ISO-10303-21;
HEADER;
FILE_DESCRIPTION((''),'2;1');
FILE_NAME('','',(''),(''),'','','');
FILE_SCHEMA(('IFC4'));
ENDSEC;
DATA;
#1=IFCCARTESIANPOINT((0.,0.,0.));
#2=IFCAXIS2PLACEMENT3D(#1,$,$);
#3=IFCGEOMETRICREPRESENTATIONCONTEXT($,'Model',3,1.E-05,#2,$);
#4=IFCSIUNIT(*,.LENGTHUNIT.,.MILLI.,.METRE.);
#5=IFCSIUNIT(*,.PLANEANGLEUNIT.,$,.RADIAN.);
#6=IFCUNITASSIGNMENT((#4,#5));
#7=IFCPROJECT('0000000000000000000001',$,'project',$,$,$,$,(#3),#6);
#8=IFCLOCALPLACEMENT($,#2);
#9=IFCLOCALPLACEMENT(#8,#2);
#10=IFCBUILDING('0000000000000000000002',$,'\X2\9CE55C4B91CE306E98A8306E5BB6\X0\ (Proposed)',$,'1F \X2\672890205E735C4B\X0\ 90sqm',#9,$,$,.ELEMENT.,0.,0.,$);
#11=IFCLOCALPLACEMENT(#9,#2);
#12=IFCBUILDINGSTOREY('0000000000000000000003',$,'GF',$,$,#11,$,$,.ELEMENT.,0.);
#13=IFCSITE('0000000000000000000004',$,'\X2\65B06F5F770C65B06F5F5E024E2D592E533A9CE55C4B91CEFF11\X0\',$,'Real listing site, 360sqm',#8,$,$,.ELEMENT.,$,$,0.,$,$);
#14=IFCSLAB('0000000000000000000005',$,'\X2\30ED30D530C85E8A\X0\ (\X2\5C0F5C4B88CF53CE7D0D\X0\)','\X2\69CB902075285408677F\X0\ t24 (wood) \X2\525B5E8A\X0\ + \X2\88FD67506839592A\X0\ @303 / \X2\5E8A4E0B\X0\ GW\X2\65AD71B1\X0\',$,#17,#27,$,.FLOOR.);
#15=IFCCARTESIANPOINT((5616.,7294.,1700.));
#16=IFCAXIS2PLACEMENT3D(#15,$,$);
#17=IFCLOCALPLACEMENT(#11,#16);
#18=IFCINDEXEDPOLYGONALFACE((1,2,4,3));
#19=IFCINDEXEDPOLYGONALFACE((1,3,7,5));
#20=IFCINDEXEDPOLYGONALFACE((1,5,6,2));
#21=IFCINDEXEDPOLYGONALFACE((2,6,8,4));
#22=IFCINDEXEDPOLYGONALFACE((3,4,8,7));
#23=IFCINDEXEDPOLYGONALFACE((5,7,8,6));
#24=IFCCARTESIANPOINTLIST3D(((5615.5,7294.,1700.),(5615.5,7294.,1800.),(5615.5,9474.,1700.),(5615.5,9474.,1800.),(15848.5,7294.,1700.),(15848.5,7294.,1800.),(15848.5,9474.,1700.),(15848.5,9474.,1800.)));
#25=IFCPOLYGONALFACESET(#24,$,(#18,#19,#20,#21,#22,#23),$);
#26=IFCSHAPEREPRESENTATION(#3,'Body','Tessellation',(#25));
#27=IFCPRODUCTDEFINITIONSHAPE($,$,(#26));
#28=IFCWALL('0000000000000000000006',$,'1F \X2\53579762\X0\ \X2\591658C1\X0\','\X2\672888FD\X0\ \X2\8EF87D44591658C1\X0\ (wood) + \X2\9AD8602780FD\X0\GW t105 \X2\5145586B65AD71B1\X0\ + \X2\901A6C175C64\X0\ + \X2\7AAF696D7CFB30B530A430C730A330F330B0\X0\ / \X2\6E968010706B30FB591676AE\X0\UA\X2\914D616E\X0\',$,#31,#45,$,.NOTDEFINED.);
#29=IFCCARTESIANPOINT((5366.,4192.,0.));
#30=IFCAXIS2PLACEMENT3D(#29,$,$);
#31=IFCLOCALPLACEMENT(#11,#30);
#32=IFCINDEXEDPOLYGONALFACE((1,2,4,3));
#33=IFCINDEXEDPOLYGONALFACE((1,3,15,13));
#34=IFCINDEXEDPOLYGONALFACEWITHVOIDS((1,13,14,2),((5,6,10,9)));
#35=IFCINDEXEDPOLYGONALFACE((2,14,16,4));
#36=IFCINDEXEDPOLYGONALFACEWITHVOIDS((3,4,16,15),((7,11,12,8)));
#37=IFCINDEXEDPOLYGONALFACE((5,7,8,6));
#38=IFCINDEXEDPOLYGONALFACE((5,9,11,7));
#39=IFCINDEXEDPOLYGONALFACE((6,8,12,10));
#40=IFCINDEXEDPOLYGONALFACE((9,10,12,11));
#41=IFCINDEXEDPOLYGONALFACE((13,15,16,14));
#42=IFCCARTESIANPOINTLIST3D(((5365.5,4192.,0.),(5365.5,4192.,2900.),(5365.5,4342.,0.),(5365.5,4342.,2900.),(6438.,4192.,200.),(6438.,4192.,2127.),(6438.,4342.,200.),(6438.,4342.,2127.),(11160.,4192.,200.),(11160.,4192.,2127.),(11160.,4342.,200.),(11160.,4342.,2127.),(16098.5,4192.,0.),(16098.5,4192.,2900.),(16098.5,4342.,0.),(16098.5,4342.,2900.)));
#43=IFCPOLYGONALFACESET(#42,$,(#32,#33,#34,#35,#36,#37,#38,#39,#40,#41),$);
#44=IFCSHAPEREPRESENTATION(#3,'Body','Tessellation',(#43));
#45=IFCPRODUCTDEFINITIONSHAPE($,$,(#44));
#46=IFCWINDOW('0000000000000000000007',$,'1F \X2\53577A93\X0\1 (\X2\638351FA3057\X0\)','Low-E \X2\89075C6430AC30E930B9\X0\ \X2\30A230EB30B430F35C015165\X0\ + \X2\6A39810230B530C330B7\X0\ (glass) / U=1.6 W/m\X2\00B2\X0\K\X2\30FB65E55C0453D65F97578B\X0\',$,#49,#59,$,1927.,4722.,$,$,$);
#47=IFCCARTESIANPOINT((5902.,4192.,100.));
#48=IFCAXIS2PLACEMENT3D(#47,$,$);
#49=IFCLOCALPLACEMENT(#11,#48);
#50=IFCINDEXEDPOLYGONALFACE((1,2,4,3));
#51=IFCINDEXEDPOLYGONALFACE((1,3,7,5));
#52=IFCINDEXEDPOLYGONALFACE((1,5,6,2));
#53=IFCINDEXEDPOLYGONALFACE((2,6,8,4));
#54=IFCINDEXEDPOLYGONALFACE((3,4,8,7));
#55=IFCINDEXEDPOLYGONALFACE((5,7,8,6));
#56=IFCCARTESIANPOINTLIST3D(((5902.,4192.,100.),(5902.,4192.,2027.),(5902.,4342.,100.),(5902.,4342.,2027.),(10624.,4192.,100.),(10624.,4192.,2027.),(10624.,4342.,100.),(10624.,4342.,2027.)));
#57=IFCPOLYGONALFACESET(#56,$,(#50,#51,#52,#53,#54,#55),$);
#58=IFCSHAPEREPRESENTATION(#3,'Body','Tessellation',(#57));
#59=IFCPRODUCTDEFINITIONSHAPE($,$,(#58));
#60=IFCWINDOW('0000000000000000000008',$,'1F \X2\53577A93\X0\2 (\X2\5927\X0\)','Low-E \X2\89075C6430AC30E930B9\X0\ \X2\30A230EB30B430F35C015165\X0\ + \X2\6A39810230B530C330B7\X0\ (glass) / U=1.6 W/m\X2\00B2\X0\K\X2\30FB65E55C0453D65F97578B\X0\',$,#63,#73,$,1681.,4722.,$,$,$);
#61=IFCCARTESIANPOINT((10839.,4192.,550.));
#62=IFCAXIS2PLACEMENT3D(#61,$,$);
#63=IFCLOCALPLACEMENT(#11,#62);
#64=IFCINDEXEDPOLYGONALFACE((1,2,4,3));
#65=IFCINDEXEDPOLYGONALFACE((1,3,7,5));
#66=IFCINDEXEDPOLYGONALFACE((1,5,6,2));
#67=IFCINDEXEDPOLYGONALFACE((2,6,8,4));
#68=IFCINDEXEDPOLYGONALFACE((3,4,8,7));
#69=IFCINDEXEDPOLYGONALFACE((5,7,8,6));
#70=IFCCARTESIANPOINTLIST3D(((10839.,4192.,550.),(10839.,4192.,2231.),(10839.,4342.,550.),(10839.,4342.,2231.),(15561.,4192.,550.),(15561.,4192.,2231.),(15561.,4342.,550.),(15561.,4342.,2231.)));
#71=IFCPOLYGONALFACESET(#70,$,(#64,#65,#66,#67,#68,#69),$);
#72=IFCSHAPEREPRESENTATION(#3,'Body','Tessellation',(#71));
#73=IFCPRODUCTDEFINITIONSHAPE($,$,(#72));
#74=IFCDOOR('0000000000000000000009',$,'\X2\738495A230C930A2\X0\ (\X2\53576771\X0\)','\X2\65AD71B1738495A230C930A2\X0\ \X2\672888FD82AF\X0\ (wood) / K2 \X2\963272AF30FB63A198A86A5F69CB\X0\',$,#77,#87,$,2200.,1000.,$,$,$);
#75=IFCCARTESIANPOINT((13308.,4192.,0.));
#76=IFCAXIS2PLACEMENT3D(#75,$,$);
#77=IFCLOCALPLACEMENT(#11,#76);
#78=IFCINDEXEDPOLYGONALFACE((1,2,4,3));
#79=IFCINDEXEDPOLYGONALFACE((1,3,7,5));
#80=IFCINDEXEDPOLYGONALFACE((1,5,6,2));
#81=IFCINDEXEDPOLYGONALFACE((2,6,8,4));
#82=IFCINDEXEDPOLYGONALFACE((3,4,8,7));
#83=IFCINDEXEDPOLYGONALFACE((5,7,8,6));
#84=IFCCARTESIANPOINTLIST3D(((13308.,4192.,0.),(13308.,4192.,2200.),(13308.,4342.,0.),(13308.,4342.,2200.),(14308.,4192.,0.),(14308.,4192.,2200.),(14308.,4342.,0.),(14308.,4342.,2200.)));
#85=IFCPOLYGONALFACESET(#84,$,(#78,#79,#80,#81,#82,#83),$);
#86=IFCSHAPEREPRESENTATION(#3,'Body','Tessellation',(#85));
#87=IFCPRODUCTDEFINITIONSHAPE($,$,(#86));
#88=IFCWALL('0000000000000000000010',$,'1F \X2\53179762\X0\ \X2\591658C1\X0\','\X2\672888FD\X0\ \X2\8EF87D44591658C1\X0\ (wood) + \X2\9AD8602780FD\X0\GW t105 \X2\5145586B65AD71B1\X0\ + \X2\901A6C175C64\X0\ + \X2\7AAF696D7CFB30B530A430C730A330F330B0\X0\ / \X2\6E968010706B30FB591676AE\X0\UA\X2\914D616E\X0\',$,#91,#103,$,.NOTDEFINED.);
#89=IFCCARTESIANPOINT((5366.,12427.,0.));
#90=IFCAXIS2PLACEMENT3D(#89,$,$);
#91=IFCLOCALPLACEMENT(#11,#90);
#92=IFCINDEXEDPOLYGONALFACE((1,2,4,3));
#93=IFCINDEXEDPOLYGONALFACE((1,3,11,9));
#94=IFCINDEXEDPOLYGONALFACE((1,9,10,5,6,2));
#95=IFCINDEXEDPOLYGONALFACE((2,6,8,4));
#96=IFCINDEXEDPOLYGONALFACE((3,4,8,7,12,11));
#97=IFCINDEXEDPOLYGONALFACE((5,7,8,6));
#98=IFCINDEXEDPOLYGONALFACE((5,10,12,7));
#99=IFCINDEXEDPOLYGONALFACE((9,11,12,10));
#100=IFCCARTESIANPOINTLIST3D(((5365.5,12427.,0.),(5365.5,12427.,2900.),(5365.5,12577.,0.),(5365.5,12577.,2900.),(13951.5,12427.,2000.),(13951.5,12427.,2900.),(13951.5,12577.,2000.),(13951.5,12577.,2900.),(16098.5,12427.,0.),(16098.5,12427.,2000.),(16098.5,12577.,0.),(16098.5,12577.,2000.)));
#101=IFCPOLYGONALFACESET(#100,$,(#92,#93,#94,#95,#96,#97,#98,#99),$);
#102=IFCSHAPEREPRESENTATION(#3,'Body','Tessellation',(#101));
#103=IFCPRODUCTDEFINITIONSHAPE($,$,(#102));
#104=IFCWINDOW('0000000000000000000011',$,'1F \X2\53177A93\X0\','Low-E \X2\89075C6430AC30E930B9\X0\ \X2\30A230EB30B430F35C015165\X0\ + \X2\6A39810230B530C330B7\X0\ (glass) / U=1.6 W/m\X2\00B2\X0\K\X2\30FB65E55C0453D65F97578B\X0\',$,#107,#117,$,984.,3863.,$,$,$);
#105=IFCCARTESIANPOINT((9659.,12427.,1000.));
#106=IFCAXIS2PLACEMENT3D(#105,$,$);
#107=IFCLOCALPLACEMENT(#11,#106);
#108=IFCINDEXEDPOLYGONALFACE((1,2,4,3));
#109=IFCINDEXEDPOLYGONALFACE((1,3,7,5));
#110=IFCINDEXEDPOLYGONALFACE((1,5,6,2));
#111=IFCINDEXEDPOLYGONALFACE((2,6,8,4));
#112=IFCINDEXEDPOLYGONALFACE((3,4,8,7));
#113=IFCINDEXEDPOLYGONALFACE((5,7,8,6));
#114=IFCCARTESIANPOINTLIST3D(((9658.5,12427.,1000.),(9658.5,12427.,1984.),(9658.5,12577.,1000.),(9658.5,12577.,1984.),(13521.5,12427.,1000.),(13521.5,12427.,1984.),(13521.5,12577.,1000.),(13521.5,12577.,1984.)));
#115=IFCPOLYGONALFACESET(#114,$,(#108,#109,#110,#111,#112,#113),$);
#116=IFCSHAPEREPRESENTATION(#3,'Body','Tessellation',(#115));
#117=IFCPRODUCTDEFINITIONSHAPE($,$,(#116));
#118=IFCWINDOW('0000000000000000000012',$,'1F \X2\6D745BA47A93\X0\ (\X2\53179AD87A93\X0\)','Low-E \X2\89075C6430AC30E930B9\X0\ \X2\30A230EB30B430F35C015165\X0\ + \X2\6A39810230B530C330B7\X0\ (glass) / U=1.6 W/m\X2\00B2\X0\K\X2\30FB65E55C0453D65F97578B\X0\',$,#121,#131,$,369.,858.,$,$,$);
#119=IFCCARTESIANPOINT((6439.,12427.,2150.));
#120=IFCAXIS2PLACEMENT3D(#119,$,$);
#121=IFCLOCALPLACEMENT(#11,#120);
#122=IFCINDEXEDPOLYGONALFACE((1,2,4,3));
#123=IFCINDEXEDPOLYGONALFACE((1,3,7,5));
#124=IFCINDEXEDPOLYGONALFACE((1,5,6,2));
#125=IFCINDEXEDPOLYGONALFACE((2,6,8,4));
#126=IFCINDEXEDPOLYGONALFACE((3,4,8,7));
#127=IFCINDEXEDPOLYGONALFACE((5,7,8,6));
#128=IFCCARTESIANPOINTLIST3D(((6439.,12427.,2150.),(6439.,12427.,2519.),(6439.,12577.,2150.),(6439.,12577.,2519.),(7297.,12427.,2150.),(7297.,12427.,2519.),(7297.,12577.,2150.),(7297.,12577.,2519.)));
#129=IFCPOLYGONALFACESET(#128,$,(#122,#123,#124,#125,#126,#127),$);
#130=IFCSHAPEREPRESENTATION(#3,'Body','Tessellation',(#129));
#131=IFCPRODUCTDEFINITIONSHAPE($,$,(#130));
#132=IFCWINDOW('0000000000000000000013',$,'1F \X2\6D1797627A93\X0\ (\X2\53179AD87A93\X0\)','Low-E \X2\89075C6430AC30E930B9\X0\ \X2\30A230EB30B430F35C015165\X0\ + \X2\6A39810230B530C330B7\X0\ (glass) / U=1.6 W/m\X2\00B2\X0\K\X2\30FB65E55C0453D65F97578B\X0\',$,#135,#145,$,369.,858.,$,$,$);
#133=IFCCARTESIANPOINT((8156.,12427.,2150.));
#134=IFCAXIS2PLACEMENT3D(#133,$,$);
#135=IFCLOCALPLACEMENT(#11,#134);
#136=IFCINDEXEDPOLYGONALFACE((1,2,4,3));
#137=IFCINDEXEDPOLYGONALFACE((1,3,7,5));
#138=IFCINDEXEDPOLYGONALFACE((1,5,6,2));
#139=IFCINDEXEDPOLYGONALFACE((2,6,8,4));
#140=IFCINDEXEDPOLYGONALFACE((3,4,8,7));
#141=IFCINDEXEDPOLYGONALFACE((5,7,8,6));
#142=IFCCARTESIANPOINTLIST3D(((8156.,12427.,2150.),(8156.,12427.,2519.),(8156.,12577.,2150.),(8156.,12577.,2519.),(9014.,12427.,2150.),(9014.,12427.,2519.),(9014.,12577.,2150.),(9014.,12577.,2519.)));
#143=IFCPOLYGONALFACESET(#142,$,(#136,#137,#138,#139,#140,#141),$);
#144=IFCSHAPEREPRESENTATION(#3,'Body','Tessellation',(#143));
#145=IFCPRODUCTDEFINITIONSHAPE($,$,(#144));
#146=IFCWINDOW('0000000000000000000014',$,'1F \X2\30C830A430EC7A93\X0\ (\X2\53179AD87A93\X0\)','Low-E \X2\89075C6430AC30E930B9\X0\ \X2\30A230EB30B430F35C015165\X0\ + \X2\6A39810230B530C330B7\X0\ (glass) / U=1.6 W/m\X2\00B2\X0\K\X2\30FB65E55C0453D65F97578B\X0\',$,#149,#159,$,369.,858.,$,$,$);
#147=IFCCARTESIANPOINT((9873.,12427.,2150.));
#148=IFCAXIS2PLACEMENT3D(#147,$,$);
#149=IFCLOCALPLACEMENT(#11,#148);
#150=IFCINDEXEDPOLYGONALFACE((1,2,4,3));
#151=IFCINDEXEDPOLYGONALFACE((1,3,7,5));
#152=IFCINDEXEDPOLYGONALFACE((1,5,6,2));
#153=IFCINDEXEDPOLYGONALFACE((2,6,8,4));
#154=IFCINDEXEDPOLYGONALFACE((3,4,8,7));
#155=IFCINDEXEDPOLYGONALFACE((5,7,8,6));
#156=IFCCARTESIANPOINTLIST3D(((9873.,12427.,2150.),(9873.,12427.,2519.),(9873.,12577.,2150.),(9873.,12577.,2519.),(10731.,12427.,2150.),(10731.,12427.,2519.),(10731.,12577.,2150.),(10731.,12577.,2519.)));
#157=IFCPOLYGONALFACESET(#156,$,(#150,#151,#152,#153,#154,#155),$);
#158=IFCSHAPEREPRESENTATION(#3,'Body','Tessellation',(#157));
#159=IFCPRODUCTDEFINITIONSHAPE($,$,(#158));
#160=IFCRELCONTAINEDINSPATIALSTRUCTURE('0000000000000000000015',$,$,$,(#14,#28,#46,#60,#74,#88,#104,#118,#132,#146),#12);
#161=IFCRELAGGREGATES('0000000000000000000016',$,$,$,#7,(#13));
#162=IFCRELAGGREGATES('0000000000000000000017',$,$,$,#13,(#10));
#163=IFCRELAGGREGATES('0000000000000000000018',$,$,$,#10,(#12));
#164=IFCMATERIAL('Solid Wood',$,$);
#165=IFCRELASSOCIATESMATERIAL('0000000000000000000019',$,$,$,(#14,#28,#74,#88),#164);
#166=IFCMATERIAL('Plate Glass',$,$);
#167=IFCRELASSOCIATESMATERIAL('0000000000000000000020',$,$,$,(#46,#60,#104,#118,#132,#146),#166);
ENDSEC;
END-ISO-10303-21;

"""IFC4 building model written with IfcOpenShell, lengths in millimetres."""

from ifc_helpers import new_model, si_unit, frame, frame_2d, origin, place, context, project, spatial, rectangle, extrude, material, element, fill, save


model = new_model("IFC4")

# Units and contexts
model_context = context("Model", 3, precision=1e-05, world=origin())
ifc_project = project(units=[si_unit("LENGTHUNIT", "METRE", prefix="MILLI"), si_unit("PLANEANGLEUNIT", "RADIAN")], contexts=[model_context])

# Site, building, storey
site_placement = place(None, origin())
site = spatial("IfcSite", under=ifc_project, at=site_placement, Name="新潟県新潟市中央区鳥屋野１", ObjectType="Real listing site, 360sqm", CompositionType="ELEMENT", RefElevation=0.0)
building_placement = place(site_placement, origin())
building = spatial("IfcBuilding", under=site, at=building_placement, Name="鳥屋野の風の家 (Proposed)", ObjectType="1F 木造平屋 90sqm", CompositionType="ELEMENT", ElevationOfRefHeight=0.0, ElevationOfTerrain=0.0)
storey_placement = place(building_placement, origin())
storey = spatial("IfcBuildingStorey", under=building, at=storey_placement, Name="GF", CompositionType="ELEMENT", Elevation=0.0)

# Slab
ifc_material_1 = material(Name="Solid Wood")
slab_1_placement = place(storey_placement, frame((5616.0, 7294.0, 1700.0)))
element("IfcSlab", 1, at=slab_1_placement, inside=storey, material=ifc_material_1, Name="ロフト床 (小屋裏収納)", Description="構造用合板 t24 (wood) 剛床 + 製材根太 @303 / 床下 GW断熱", PredefinedType="FLOOR", context=model_context, shape_type="SweptSolid", body=[
    extrude(rectangle(XDim=10233.0, YDim=2180.0, at=frame_2d((5116.0, 1090.0))), frame((5616.0, 7294.0, 1700.0)), (0.0, 0.0, 1.0), 100.0),
])

# Wall, openings, windows, door
wall_1_placement = place(storey_placement, frame((5366.0, 4192.0, 0.0)))
wall_1 = element("IfcWall", 2, at=wall_1_placement, inside=storey, material=ifc_material_1, Name="1F 南面 外壁", Description="木製 軸組外壁 (wood) + 高性能GW t105 充填断熱 + 通気層 + 窯業系サイディング / 準耐火・外皮UA配慮", PredefinedType="NOTDEFINED", context=model_context, shape_type="SweptSolid", body=[
    extrude(rectangle(XDim=10733.0, YDim=150.0, at=frame_2d((5366.0, 75.0))), frame((5366.0, 4192.0, 0.0)), (0.0, 0.0, 1.0), 2900.0),
])
opening_1_placement = place(storey_placement, frame((5902.0, 4192.0, 100.0)))
opening_1 = element("IfcOpeningElement", 3, at=opening_1_placement, cuts=wall_1, PredefinedType="NOTDEFINED", context=model_context, shape_type="SweptSolid", body=[
    extrude(rectangle(XDim=4722.0, YDim=150.0, at=frame_2d((2361.0, 75.0))), frame((5902.0, 4192.0, 100.0)), (0.0, 0.0, 1.0), 1927.0),
])
opening_2_placement = place(storey_placement, frame((10839.0, 4192.0, 550.0)))
opening_2 = element("IfcOpeningElement", 4, at=opening_2_placement, cuts=wall_1, PredefinedType="NOTDEFINED", context=model_context, shape_type="SweptSolid", body=[
    extrude(rectangle(XDim=4722.0, YDim=150.0, at=frame_2d((2361.0, 75.0))), frame((10839.0, 4192.0, 550.0)), (0.0, 0.0, 1.0), 1681.0),
])
opening_3_placement = place(storey_placement, frame((13308.0, 4192.0, 0.0)))
opening_3 = element("IfcOpeningElement", 5, at=opening_3_placement, cuts=wall_1, PredefinedType="NOTDEFINED", context=model_context, shape_type="SweptSolid", body=[
    extrude(rectangle(XDim=1000.0, YDim=150.0, at=frame_2d((500.0, 75.0))), frame((13308.0, 4192.0, 0.0)), (0.0, 0.0, 1.0), 2200.0),
])
ifc_material_2 = material(Name="Plate Glass")
window_1_placement = place(storey_placement, frame((5902.0, 4192.0, 100.0)))
window_1 = element("IfcWindow", 6, at=window_1_placement, inside=storey, material=ifc_material_2, Name="1F 南窓1 (掃出し)", Description="Low-E 複層ガラス アルゴン封入 + 樹脂サッシ (glass) / U=1.6 W/m²K・日射取得型", OverallHeight=1927.0, OverallWidth=4722.0, context=model_context, shape_type="SweptSolid", body=[
    extrude(rectangle(XDim=4722.0, YDim=150.0, at=frame_2d((2361.0, 75.0))), frame((5902.0, 4192.0, 100.0)), (0.0, 0.0, 1.0), 1927.0),
])
fill(opening_1, window_1)
window_2_placement = place(storey_placement, frame((10839.0, 4192.0, 550.0)))
window_2 = element("IfcWindow", 7, at=window_2_placement, inside=storey, material=ifc_material_2, Name="1F 南窓2 (大)", Description="Low-E 複層ガラス アルゴン封入 + 樹脂サッシ (glass) / U=1.6 W/m²K・日射取得型", OverallHeight=1681.0, OverallWidth=4722.0, context=model_context, shape_type="SweptSolid", body=[
    extrude(rectangle(XDim=4722.0, YDim=150.0, at=frame_2d((2361.0, 75.0))), frame((10839.0, 4192.0, 550.0)), (0.0, 0.0, 1.0), 1681.0),
])
fill(opening_2, window_2)
door_1_placement = place(storey_placement, frame((13308.0, 4192.0, 0.0)))
door_1 = element("IfcDoor", 8, at=door_1_placement, inside=storey, material=ifc_material_1, Name="玄関ドア (南東)", Description="断熱玄関ドア 木製芯 (wood) / K2 防犯・採風機構", OverallHeight=2200.0, OverallWidth=1000.0, context=model_context, shape_type="SweptSolid", body=[
    extrude(rectangle(XDim=1000.0, YDim=150.0, at=frame_2d((500.0, 75.0))), frame((13308.0, 4192.0, 0.0)), (0.0, 0.0, 1.0), 2200.0),
])
fill(opening_3, door_1)

# Wall, openings, windows
wall_2_placement = place(storey_placement, frame((5366.0, 12427.0, 0.0)))
wall_2 = element("IfcWall", 9, at=wall_2_placement, inside=storey, material=ifc_material_1, Name="1F 北面 外壁", Description="木製 軸組外壁 (wood) + 高性能GW t105 充填断熱 + 通気層 + 窯業系サイディング / 準耐火・外皮UA配慮", PredefinedType="NOTDEFINED", context=model_context, shape_type="SweptSolid", body=[
    extrude(rectangle(XDim=10733.0, YDim=150.0, at=frame_2d((5366.0, 75.0))), frame((5366.0, 12427.0, 0.0)), (0.0, 0.0, 1.0), 2900.0),
])
opening_4_placement = place(storey_placement, frame((9659.0, 12427.0, 1000.0)))
opening_4 = element("IfcOpeningElement", 10, at=opening_4_placement, cuts=wall_2, PredefinedType="NOTDEFINED", context=model_context, shape_type="SweptSolid", body=[
    extrude(rectangle(XDim=3863.0, YDim=150.0, at=frame_2d((1931.0, 75.0))), frame((9659.0, 12427.0, 1000.0)), (0.0, 0.0, 1.0), 984.0),
])
opening_5_placement = place(storey_placement, frame((6439.0, 12427.0, 2150.0)))
opening_5 = element("IfcOpeningElement", 11, at=opening_5_placement, cuts=wall_2, PredefinedType="NOTDEFINED", context=model_context, shape_type="SweptSolid", body=[
    extrude(rectangle(XDim=858.0, YDim=150.0, at=frame_2d((429.0, 75.0))), frame((6439.0, 12427.0, 2150.0)), (0.0, 0.0, 1.0), 369.0),
])
opening_6_placement = place(storey_placement, frame((8156.0, 12427.0, 2150.0)))
opening_6 = element("IfcOpeningElement", 12, at=opening_6_placement, cuts=wall_2, PredefinedType="NOTDEFINED", context=model_context, shape_type="SweptSolid", body=[
    extrude(rectangle(XDim=858.0, YDim=150.0, at=frame_2d((429.0, 75.0))), frame((8156.0, 12427.0, 2150.0)), (0.0, 0.0, 1.0), 369.0),
])
opening_7_placement = place(storey_placement, frame((9873.0, 12427.0, 2150.0)))
opening_7 = element("IfcOpeningElement", 13, at=opening_7_placement, cuts=wall_2, PredefinedType="NOTDEFINED", context=model_context, shape_type="SweptSolid", body=[
    extrude(rectangle(XDim=858.0, YDim=150.0, at=frame_2d((429.0, 75.0))), frame((9873.0, 12427.0, 2150.0)), (0.0, 0.0, 1.0), 369.0),
])
window_3_placement = place(storey_placement, frame((9659.0, 12427.0, 1000.0)))
window_3 = element("IfcWindow", 14, at=window_3_placement, inside=storey, material=ifc_material_2, Name="1F 北窓", Description="Low-E 複層ガラス アルゴン封入 + 樹脂サッシ (glass) / U=1.6 W/m²K・日射取得型", OverallHeight=984.0, OverallWidth=3863.0, context=model_context, shape_type="SweptSolid", body=[
    extrude(rectangle(XDim=3863.0, YDim=150.0, at=frame_2d((1931.0, 75.0))), frame((9659.0, 12427.0, 1000.0)), (0.0, 0.0, 1.0), 984.0),
])
fill(opening_4, window_3)
window_4_placement = place(storey_placement, frame((6439.0, 12427.0, 2150.0)))
window_4 = element("IfcWindow", 15, at=window_4_placement, inside=storey, material=ifc_material_2, Name="1F 浴室窓 (北高窓)", Description="Low-E 複層ガラス アルゴン封入 + 樹脂サッシ (glass) / U=1.6 W/m²K・日射取得型", OverallHeight=369.0, OverallWidth=858.0, context=model_context, shape_type="SweptSolid", body=[
    extrude(rectangle(XDim=858.0, YDim=150.0, at=frame_2d((429.0, 75.0))), frame((6439.0, 12427.0, 2150.0)), (0.0, 0.0, 1.0), 369.0),
])
fill(opening_5, window_4)
window_5_placement = place(storey_placement, frame((8156.0, 12427.0, 2150.0)))
window_5 = element("IfcWindow", 16, at=window_5_placement, inside=storey, material=ifc_material_2, Name="1F 洗面窓 (北高窓)", Description="Low-E 複層ガラス アルゴン封入 + 樹脂サッシ (glass) / U=1.6 W/m²K・日射取得型", OverallHeight=369.0, OverallWidth=858.0, context=model_context, shape_type="SweptSolid", body=[
    extrude(rectangle(XDim=858.0, YDim=150.0, at=frame_2d((429.0, 75.0))), frame((8156.0, 12427.0, 2150.0)), (0.0, 0.0, 1.0), 369.0),
])
fill(opening_6, window_5)
window_6_placement = place(storey_placement, frame((9873.0, 12427.0, 2150.0)))
window_6 = element("IfcWindow", 17, at=window_6_placement, inside=storey, material=ifc_material_2, Name="1F トイレ窓 (北高窓)", Description="Low-E 複層ガラス アルゴン封入 + 樹脂サッシ (glass) / U=1.6 W/m²K・日射取得型", OverallHeight=369.0, OverallWidth=858.0, context=model_context, shape_type="SweptSolid", body=[
    extrude(rectangle(XDim=858.0, YDim=150.0, at=frame_2d((429.0, 75.0))), frame((9873.0, 12427.0, 2150.0)), (0.0, 0.0, 1.0), 369.0),
])
fill(opening_7, window_6)

save(model, "model.ifc")
